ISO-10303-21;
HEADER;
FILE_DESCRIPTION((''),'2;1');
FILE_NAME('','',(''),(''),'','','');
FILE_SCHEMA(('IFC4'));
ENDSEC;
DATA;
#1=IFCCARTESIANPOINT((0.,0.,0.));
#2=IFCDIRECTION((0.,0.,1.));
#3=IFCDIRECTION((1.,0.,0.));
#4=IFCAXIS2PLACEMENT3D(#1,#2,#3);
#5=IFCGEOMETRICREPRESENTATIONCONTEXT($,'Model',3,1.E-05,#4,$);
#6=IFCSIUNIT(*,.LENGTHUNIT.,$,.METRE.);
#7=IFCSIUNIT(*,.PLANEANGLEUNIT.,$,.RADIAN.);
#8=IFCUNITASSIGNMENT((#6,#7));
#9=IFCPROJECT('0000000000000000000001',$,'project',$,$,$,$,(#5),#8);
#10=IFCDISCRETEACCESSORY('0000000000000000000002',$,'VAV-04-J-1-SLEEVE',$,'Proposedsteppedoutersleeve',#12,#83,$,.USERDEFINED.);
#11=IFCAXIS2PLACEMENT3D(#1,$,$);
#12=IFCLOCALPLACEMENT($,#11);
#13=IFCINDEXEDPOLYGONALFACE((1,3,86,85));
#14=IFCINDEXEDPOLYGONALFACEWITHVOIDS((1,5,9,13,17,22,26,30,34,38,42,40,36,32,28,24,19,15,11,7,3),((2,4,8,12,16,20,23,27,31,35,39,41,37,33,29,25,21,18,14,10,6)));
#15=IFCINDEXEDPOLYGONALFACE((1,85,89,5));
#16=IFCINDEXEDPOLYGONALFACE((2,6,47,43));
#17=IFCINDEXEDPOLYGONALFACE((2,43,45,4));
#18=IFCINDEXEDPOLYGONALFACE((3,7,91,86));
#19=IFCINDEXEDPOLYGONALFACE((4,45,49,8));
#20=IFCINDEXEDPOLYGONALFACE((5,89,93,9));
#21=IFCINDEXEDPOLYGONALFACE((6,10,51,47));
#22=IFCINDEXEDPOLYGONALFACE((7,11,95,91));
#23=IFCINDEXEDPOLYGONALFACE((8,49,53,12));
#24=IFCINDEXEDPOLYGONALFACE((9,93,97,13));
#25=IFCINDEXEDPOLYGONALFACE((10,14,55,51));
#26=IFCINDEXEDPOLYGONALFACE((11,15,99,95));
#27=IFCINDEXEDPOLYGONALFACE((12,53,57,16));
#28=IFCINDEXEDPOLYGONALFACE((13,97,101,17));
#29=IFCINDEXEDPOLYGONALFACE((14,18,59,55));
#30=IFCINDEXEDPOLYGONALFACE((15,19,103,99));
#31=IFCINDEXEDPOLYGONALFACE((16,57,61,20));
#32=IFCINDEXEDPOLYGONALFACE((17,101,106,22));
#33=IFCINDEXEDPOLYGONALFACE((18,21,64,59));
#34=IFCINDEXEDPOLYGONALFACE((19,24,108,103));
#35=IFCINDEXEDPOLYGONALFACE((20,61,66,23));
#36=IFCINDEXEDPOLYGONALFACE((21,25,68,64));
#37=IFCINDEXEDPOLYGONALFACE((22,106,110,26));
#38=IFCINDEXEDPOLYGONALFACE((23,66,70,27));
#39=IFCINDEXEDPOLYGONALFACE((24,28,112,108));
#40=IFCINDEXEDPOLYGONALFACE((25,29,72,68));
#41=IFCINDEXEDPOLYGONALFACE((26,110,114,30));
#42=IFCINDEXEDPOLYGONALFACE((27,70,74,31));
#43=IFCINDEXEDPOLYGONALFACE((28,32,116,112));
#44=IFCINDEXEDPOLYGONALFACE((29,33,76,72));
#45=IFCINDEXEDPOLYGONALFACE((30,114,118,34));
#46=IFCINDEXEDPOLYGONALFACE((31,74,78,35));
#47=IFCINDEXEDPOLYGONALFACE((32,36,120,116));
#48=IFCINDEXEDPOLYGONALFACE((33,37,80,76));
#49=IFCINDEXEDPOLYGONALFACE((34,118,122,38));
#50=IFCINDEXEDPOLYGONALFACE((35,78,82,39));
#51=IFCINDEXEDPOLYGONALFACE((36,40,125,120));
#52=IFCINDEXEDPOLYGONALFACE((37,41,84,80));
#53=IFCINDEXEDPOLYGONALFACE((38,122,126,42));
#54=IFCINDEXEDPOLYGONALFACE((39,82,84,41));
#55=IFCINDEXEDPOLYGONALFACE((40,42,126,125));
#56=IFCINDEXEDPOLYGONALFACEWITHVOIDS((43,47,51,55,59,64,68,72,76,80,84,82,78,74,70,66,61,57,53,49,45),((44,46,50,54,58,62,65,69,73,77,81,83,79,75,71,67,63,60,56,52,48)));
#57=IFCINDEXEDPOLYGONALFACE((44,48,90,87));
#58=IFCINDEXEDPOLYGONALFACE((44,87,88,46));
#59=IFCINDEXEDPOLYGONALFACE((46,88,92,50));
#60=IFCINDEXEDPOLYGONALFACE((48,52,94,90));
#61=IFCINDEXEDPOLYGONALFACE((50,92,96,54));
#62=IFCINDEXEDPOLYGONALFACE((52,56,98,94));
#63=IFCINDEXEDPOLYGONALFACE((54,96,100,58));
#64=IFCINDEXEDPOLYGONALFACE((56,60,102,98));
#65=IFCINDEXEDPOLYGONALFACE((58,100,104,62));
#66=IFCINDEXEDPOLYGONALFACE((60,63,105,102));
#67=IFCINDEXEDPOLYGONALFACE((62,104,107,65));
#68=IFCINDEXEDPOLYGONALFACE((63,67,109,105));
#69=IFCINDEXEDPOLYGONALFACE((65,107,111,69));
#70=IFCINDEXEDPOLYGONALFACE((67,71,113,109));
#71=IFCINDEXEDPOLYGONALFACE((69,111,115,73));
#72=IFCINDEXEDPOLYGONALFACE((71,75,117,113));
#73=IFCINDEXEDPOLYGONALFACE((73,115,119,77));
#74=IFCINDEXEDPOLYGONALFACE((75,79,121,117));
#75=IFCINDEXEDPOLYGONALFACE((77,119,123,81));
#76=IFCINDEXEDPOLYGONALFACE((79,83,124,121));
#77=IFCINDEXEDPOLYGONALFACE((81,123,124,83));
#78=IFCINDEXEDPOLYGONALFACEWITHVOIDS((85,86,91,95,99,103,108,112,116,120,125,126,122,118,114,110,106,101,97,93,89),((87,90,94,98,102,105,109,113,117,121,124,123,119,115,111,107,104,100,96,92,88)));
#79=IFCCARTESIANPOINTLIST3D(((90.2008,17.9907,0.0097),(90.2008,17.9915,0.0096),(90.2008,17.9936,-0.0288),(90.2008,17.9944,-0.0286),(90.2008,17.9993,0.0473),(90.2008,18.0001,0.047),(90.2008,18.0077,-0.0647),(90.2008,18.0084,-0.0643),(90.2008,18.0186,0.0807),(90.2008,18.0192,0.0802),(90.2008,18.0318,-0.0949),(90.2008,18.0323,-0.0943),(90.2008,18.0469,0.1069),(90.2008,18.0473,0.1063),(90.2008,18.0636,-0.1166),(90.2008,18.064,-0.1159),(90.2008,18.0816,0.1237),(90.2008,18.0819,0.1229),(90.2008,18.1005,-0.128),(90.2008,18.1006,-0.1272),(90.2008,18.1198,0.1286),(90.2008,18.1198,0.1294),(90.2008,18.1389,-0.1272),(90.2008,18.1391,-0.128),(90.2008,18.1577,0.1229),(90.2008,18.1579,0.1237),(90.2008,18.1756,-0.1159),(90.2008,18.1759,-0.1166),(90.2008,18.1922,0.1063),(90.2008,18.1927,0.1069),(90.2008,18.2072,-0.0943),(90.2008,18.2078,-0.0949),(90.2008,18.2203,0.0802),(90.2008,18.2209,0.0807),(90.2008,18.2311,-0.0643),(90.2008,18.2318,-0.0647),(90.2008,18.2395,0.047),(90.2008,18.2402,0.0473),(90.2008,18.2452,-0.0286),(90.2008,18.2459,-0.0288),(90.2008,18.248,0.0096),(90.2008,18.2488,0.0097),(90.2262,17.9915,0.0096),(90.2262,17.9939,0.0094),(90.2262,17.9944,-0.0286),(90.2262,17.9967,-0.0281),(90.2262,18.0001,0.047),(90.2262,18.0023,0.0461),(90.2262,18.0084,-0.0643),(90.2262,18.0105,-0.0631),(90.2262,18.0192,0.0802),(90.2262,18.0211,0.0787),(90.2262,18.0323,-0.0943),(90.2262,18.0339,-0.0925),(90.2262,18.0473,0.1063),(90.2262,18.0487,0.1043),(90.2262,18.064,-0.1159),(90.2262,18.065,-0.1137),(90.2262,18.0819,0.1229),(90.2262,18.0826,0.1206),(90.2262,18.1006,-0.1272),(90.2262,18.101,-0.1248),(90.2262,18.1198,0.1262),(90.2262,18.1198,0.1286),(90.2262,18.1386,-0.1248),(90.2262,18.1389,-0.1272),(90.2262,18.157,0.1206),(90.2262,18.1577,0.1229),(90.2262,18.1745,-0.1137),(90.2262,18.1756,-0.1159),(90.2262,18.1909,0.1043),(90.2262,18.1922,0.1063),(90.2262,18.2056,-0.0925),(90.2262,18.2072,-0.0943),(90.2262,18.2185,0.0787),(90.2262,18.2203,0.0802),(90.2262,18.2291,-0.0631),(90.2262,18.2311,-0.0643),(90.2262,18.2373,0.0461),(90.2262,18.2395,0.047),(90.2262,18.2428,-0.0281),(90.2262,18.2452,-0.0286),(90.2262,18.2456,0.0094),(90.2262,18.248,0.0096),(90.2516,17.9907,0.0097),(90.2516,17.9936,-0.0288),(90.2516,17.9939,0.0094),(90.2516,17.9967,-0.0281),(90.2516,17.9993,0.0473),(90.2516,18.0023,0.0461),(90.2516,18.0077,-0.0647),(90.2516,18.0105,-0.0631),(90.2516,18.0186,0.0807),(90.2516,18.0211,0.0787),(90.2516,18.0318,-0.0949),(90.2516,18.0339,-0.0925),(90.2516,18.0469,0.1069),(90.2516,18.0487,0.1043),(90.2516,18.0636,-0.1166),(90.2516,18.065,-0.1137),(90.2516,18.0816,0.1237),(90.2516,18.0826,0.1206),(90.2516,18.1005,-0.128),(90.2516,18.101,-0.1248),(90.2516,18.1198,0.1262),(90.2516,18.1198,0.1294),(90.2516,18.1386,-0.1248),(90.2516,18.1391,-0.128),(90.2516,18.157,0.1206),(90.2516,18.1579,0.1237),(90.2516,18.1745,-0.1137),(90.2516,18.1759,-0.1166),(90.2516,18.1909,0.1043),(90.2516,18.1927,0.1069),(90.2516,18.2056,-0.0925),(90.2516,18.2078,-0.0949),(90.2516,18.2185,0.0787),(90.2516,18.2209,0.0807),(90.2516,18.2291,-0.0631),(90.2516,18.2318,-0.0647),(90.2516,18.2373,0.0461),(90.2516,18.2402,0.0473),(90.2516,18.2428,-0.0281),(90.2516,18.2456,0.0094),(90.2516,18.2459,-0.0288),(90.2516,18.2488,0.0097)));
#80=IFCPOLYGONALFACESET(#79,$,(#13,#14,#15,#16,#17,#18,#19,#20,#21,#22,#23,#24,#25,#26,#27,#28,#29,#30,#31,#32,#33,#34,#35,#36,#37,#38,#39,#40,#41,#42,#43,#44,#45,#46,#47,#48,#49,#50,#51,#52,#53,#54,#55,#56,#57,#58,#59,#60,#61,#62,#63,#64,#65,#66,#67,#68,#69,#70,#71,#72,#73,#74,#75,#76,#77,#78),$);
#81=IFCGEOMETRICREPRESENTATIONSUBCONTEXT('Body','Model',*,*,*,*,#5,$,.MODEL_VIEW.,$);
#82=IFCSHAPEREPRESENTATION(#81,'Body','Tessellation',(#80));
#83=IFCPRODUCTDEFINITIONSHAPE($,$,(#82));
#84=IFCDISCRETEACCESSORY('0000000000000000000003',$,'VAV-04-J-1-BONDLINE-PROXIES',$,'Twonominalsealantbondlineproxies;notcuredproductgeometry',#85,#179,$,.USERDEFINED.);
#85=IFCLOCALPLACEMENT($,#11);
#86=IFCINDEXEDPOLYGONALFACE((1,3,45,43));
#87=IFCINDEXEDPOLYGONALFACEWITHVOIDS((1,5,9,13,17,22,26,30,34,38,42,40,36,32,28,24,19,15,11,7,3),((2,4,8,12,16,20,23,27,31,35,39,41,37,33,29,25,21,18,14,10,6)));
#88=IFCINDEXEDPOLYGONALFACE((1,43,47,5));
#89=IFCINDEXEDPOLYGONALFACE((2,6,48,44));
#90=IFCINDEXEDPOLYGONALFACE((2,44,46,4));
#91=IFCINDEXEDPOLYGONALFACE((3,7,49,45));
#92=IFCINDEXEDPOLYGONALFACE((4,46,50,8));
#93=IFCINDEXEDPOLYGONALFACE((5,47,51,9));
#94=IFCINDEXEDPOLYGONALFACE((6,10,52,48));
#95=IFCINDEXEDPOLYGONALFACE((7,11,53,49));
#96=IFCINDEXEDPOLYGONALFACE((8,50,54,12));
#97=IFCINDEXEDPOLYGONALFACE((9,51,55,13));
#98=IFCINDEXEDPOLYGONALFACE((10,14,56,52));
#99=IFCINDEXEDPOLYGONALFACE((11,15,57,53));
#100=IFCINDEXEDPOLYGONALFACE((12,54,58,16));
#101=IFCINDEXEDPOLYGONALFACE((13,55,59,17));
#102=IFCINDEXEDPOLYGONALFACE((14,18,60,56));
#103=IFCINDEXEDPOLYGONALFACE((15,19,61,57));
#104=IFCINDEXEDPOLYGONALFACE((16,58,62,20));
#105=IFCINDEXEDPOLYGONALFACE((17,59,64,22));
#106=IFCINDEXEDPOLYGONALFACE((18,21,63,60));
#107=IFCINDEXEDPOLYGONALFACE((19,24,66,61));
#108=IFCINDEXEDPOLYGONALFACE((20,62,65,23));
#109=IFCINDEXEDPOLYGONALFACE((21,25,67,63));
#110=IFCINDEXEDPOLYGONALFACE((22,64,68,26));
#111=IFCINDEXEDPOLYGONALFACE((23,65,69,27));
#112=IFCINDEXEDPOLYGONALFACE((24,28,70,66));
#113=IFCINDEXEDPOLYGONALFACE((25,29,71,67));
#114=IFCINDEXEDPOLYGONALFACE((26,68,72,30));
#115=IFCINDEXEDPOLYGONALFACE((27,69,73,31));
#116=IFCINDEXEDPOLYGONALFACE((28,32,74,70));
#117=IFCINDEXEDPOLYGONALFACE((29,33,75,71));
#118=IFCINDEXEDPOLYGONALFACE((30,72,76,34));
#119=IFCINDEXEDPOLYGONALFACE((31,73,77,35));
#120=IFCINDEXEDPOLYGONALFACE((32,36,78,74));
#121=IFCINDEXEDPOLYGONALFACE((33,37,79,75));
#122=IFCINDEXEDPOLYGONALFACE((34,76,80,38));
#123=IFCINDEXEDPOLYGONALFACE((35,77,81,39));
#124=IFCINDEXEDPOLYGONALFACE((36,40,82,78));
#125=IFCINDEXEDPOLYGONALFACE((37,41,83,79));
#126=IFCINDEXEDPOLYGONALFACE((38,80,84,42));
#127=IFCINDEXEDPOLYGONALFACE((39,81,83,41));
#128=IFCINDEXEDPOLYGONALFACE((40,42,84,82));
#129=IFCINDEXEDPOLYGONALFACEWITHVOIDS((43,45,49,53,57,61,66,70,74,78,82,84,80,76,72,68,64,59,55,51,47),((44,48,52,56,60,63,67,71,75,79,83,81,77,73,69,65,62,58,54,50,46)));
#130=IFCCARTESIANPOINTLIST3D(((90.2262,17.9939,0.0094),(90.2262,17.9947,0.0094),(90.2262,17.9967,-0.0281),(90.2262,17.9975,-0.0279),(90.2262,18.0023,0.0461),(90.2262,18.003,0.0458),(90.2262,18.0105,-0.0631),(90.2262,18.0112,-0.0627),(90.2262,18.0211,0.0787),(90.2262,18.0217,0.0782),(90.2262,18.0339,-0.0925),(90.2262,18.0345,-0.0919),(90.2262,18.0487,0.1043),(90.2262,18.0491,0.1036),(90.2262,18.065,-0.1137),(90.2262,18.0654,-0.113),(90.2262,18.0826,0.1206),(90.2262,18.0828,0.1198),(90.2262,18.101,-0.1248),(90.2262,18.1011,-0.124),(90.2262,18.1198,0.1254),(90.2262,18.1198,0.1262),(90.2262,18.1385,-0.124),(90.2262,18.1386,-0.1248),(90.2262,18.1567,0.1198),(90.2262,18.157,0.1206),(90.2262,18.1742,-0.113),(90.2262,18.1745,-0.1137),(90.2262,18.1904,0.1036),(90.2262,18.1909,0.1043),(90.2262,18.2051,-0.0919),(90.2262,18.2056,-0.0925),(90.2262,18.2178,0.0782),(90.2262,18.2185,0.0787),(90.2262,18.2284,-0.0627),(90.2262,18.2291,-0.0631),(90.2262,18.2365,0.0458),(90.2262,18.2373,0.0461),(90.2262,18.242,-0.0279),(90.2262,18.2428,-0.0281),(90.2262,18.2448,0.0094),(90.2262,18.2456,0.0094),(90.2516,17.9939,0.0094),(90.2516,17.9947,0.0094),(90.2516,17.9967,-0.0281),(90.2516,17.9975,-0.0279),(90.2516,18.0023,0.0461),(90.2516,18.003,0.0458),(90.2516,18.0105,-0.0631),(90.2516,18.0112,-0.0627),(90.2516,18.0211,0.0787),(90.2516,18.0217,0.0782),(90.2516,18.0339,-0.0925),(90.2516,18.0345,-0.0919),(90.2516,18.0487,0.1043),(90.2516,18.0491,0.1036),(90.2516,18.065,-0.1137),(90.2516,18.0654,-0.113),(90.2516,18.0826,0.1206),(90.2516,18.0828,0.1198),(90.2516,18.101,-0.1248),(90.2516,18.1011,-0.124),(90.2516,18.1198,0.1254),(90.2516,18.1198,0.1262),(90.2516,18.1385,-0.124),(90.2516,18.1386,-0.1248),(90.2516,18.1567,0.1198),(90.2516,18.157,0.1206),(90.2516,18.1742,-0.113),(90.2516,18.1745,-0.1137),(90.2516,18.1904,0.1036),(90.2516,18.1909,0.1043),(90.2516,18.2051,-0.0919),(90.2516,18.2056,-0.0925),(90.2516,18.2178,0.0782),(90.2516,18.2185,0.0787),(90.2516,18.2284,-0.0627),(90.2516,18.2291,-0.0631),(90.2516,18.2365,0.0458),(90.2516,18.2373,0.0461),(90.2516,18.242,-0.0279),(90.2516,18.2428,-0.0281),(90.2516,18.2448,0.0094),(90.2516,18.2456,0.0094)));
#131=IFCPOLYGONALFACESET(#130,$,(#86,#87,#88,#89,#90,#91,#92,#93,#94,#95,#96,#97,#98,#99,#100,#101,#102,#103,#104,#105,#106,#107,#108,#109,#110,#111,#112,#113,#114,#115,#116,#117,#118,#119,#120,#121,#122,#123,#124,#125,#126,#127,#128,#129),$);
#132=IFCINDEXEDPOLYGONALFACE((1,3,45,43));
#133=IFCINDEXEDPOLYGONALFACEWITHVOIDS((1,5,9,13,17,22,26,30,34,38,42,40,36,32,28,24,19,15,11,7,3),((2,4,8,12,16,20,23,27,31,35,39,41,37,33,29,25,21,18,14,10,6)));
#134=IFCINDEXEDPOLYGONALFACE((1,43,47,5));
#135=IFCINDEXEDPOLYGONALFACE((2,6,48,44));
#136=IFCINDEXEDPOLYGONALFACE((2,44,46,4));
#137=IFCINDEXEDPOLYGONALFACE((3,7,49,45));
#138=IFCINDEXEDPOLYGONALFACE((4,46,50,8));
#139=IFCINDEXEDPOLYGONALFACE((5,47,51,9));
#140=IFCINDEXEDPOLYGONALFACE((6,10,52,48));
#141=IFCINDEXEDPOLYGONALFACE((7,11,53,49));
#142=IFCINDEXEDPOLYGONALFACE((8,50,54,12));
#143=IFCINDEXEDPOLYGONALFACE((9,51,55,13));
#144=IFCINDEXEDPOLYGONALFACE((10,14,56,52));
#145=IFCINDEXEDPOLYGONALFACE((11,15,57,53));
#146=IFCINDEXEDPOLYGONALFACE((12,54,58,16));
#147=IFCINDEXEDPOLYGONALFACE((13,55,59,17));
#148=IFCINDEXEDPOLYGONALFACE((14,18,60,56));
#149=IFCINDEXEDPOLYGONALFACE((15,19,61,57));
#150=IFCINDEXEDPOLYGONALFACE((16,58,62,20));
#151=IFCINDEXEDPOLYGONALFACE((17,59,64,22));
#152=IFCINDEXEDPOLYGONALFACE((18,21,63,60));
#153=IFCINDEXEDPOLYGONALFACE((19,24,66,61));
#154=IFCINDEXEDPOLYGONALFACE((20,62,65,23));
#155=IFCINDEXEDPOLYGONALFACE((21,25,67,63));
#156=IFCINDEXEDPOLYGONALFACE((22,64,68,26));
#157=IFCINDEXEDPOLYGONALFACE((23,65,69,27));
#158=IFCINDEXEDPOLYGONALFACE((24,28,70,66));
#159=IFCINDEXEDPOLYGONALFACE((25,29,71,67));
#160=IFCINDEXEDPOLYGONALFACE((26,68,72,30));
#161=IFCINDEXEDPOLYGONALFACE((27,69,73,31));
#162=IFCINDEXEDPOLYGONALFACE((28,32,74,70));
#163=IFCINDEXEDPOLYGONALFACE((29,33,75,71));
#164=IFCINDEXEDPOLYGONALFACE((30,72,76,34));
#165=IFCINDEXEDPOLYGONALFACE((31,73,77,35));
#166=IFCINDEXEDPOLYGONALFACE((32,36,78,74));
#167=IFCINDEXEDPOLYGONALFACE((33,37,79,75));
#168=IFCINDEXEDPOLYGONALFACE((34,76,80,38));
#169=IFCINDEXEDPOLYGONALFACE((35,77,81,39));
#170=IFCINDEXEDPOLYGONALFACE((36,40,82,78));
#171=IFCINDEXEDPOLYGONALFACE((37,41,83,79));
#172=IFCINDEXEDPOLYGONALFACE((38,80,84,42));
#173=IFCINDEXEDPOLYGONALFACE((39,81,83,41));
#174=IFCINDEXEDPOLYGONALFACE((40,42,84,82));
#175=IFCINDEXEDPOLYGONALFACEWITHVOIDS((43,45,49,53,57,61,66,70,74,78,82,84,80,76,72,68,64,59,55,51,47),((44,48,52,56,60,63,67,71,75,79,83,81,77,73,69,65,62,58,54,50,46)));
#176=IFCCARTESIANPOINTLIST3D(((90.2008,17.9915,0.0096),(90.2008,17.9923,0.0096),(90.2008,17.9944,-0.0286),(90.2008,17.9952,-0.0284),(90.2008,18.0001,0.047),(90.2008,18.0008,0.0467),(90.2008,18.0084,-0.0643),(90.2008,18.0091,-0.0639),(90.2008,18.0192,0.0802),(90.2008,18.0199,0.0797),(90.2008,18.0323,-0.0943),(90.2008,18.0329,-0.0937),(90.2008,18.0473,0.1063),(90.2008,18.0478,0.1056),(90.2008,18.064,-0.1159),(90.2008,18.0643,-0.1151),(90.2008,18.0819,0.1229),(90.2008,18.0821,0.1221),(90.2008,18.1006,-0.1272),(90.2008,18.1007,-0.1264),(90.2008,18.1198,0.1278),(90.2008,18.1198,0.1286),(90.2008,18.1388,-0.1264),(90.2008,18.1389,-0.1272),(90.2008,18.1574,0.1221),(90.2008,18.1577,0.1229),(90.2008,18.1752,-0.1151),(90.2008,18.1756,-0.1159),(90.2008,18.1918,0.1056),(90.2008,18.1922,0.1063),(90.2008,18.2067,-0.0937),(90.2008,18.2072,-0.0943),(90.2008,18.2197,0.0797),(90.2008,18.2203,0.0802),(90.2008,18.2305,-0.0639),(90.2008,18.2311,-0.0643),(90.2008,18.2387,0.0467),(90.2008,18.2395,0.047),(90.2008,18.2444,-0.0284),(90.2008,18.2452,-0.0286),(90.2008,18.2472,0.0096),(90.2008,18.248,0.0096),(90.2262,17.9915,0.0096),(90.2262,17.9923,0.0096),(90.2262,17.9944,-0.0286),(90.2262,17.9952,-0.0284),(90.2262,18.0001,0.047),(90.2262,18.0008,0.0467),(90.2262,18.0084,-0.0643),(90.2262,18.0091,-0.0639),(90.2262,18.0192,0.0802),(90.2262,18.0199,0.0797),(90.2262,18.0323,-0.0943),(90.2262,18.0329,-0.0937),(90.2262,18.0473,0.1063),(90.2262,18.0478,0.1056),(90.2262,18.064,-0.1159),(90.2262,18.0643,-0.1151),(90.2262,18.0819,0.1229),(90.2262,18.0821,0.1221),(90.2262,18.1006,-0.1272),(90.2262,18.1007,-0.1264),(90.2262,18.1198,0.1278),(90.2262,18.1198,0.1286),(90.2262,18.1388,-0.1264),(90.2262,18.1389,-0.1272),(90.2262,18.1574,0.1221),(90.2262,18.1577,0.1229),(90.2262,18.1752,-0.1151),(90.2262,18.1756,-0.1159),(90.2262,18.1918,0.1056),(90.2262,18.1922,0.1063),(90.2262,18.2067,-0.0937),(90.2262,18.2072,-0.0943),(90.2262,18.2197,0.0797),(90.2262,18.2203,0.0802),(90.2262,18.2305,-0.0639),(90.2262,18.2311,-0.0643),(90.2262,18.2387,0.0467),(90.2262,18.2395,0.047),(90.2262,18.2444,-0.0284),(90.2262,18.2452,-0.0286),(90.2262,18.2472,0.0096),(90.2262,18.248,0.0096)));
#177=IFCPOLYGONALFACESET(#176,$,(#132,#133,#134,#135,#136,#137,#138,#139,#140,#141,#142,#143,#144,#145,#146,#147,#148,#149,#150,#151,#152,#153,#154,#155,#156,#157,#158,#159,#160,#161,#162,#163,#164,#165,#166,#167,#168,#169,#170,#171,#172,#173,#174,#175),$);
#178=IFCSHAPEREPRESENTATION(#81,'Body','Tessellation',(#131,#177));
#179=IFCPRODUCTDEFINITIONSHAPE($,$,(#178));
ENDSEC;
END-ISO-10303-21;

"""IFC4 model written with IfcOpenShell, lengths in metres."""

from ifc_helpers import new_model, entity, si_unit, frame, origin_with_axes, place, context, subcontext, project, element, save


model = new_model("IFC4")

# Units and contexts
model_context = context("Model", 3, precision=1e-05, world=origin_with_axes())
body_context = subcontext(model_context, "Body", "Model", "MODEL_VIEW")
ifc_project = project(units=[si_unit("LENGTHUNIT", "METRE"), si_unit("PLANEANGLEUNIT", "RADIAN")], contexts=[model_context])

# Discrete accessories
discrete_accessory_1_placement = place(None, frame((90.2262, 18.1198, 0.0), z_axis=(0.0, -1.0, 0.0), x_axis=(0.0, 0.0, 1.0)))
element("IfcDiscreteAccessory", 1, at=discrete_accessory_1_placement, Name="VAV-04-J-1-SLEEVE", ObjectType="Proposedsteppedoutersleeve", PredefinedType="USERDEFINED", context=body_context, shape_type="SweptSolid", body=[
    entity("IfcRevolvedAreaSolid", entity("IfcArbitraryClosedProfileDef", "AREA", None, entity("IfcPolyline", [entity("IfcCartesianPoint", [0.1262, -0.0254]), entity("IfcCartesianPoint", [0.1294, -0.0254]), entity("IfcCartesianPoint", [0.1294, 0.0254]), entity("IfcCartesianPoint", [0.1286, 0.0254]), entity("IfcCartesianPoint", [0.1286, 0.0]), entity("IfcCartesianPoint", [0.1262, 0.0]), entity("IfcCartesianPoint", [0.1262, -0.0254])])), entity("IfcAxis2Placement3D", entity("IfcCartesianPoint", [0.0, 0.0, 0.0])), entity("IfcAxis1Placement", entity("IfcCartesianPoint", [0.0, 0.0, 0.0]), entity("IfcDirection", [0.0, 1.0, 0.0])), 6.283185),
])
discrete_accessory_2_placement = place(None, frame((90.2262, 18.1198, 0.0), z_axis=(0.0, -1.0, 0.0), x_axis=(0.0, 0.0, 1.0)))
element("IfcDiscreteAccessory", 2, at=discrete_accessory_2_placement, Name="VAV-04-J-1-BONDLINE-PROXIES", ObjectType="Twonominalsealantbondlineproxies;notcuredproductgeometry", PredefinedType="USERDEFINED", context=body_context, shape_type="SweptSolid", body=[
    entity("IfcRevolvedAreaSolid", entity("IfcArbitraryClosedProfileDef", "AREA", None, entity("IfcPolyline", [entity("IfcCartesianPoint", [0.1254, -0.0254]), entity("IfcCartesianPoint", [0.1262, -0.0254]), entity("IfcCartesianPoint", [0.1262, 0.0]), entity("IfcCartesianPoint", [0.1254, 0.0]), entity("IfcCartesianPoint", [0.1254, -0.0254])])), entity("IfcAxis2Placement3D", entity("IfcCartesianPoint", [0.0, 0.0, 0.0])), entity("IfcAxis1Placement", entity("IfcCartesianPoint", [0.0, 0.0, 0.0]), entity("IfcDirection", [0.0, 1.0, 0.0])), 6.283185),
    entity("IfcRevolvedAreaSolid", entity("IfcArbitraryClosedProfileDef", "AREA", None, entity("IfcPolyline", [entity("IfcCartesianPoint", [0.1278, 0.0]), entity("IfcCartesianPoint", [0.1286, 0.0]), entity("IfcCartesianPoint", [0.1286, 0.0254]), entity("IfcCartesianPoint", [0.1278, 0.0254]), entity("IfcCartesianPoint", [0.1278, 0.0])])), entity("IfcAxis2Placement3D", entity("IfcCartesianPoint", [0.0, 0.0, 0.0])), entity("IfcAxis1Placement", entity("IfcCartesianPoint", [0.0, 0.0, 0.0]), entity("IfcDirection", [0.0, 1.0, 0.0])), 6.283185),
])

save(model, "model.ifc")
